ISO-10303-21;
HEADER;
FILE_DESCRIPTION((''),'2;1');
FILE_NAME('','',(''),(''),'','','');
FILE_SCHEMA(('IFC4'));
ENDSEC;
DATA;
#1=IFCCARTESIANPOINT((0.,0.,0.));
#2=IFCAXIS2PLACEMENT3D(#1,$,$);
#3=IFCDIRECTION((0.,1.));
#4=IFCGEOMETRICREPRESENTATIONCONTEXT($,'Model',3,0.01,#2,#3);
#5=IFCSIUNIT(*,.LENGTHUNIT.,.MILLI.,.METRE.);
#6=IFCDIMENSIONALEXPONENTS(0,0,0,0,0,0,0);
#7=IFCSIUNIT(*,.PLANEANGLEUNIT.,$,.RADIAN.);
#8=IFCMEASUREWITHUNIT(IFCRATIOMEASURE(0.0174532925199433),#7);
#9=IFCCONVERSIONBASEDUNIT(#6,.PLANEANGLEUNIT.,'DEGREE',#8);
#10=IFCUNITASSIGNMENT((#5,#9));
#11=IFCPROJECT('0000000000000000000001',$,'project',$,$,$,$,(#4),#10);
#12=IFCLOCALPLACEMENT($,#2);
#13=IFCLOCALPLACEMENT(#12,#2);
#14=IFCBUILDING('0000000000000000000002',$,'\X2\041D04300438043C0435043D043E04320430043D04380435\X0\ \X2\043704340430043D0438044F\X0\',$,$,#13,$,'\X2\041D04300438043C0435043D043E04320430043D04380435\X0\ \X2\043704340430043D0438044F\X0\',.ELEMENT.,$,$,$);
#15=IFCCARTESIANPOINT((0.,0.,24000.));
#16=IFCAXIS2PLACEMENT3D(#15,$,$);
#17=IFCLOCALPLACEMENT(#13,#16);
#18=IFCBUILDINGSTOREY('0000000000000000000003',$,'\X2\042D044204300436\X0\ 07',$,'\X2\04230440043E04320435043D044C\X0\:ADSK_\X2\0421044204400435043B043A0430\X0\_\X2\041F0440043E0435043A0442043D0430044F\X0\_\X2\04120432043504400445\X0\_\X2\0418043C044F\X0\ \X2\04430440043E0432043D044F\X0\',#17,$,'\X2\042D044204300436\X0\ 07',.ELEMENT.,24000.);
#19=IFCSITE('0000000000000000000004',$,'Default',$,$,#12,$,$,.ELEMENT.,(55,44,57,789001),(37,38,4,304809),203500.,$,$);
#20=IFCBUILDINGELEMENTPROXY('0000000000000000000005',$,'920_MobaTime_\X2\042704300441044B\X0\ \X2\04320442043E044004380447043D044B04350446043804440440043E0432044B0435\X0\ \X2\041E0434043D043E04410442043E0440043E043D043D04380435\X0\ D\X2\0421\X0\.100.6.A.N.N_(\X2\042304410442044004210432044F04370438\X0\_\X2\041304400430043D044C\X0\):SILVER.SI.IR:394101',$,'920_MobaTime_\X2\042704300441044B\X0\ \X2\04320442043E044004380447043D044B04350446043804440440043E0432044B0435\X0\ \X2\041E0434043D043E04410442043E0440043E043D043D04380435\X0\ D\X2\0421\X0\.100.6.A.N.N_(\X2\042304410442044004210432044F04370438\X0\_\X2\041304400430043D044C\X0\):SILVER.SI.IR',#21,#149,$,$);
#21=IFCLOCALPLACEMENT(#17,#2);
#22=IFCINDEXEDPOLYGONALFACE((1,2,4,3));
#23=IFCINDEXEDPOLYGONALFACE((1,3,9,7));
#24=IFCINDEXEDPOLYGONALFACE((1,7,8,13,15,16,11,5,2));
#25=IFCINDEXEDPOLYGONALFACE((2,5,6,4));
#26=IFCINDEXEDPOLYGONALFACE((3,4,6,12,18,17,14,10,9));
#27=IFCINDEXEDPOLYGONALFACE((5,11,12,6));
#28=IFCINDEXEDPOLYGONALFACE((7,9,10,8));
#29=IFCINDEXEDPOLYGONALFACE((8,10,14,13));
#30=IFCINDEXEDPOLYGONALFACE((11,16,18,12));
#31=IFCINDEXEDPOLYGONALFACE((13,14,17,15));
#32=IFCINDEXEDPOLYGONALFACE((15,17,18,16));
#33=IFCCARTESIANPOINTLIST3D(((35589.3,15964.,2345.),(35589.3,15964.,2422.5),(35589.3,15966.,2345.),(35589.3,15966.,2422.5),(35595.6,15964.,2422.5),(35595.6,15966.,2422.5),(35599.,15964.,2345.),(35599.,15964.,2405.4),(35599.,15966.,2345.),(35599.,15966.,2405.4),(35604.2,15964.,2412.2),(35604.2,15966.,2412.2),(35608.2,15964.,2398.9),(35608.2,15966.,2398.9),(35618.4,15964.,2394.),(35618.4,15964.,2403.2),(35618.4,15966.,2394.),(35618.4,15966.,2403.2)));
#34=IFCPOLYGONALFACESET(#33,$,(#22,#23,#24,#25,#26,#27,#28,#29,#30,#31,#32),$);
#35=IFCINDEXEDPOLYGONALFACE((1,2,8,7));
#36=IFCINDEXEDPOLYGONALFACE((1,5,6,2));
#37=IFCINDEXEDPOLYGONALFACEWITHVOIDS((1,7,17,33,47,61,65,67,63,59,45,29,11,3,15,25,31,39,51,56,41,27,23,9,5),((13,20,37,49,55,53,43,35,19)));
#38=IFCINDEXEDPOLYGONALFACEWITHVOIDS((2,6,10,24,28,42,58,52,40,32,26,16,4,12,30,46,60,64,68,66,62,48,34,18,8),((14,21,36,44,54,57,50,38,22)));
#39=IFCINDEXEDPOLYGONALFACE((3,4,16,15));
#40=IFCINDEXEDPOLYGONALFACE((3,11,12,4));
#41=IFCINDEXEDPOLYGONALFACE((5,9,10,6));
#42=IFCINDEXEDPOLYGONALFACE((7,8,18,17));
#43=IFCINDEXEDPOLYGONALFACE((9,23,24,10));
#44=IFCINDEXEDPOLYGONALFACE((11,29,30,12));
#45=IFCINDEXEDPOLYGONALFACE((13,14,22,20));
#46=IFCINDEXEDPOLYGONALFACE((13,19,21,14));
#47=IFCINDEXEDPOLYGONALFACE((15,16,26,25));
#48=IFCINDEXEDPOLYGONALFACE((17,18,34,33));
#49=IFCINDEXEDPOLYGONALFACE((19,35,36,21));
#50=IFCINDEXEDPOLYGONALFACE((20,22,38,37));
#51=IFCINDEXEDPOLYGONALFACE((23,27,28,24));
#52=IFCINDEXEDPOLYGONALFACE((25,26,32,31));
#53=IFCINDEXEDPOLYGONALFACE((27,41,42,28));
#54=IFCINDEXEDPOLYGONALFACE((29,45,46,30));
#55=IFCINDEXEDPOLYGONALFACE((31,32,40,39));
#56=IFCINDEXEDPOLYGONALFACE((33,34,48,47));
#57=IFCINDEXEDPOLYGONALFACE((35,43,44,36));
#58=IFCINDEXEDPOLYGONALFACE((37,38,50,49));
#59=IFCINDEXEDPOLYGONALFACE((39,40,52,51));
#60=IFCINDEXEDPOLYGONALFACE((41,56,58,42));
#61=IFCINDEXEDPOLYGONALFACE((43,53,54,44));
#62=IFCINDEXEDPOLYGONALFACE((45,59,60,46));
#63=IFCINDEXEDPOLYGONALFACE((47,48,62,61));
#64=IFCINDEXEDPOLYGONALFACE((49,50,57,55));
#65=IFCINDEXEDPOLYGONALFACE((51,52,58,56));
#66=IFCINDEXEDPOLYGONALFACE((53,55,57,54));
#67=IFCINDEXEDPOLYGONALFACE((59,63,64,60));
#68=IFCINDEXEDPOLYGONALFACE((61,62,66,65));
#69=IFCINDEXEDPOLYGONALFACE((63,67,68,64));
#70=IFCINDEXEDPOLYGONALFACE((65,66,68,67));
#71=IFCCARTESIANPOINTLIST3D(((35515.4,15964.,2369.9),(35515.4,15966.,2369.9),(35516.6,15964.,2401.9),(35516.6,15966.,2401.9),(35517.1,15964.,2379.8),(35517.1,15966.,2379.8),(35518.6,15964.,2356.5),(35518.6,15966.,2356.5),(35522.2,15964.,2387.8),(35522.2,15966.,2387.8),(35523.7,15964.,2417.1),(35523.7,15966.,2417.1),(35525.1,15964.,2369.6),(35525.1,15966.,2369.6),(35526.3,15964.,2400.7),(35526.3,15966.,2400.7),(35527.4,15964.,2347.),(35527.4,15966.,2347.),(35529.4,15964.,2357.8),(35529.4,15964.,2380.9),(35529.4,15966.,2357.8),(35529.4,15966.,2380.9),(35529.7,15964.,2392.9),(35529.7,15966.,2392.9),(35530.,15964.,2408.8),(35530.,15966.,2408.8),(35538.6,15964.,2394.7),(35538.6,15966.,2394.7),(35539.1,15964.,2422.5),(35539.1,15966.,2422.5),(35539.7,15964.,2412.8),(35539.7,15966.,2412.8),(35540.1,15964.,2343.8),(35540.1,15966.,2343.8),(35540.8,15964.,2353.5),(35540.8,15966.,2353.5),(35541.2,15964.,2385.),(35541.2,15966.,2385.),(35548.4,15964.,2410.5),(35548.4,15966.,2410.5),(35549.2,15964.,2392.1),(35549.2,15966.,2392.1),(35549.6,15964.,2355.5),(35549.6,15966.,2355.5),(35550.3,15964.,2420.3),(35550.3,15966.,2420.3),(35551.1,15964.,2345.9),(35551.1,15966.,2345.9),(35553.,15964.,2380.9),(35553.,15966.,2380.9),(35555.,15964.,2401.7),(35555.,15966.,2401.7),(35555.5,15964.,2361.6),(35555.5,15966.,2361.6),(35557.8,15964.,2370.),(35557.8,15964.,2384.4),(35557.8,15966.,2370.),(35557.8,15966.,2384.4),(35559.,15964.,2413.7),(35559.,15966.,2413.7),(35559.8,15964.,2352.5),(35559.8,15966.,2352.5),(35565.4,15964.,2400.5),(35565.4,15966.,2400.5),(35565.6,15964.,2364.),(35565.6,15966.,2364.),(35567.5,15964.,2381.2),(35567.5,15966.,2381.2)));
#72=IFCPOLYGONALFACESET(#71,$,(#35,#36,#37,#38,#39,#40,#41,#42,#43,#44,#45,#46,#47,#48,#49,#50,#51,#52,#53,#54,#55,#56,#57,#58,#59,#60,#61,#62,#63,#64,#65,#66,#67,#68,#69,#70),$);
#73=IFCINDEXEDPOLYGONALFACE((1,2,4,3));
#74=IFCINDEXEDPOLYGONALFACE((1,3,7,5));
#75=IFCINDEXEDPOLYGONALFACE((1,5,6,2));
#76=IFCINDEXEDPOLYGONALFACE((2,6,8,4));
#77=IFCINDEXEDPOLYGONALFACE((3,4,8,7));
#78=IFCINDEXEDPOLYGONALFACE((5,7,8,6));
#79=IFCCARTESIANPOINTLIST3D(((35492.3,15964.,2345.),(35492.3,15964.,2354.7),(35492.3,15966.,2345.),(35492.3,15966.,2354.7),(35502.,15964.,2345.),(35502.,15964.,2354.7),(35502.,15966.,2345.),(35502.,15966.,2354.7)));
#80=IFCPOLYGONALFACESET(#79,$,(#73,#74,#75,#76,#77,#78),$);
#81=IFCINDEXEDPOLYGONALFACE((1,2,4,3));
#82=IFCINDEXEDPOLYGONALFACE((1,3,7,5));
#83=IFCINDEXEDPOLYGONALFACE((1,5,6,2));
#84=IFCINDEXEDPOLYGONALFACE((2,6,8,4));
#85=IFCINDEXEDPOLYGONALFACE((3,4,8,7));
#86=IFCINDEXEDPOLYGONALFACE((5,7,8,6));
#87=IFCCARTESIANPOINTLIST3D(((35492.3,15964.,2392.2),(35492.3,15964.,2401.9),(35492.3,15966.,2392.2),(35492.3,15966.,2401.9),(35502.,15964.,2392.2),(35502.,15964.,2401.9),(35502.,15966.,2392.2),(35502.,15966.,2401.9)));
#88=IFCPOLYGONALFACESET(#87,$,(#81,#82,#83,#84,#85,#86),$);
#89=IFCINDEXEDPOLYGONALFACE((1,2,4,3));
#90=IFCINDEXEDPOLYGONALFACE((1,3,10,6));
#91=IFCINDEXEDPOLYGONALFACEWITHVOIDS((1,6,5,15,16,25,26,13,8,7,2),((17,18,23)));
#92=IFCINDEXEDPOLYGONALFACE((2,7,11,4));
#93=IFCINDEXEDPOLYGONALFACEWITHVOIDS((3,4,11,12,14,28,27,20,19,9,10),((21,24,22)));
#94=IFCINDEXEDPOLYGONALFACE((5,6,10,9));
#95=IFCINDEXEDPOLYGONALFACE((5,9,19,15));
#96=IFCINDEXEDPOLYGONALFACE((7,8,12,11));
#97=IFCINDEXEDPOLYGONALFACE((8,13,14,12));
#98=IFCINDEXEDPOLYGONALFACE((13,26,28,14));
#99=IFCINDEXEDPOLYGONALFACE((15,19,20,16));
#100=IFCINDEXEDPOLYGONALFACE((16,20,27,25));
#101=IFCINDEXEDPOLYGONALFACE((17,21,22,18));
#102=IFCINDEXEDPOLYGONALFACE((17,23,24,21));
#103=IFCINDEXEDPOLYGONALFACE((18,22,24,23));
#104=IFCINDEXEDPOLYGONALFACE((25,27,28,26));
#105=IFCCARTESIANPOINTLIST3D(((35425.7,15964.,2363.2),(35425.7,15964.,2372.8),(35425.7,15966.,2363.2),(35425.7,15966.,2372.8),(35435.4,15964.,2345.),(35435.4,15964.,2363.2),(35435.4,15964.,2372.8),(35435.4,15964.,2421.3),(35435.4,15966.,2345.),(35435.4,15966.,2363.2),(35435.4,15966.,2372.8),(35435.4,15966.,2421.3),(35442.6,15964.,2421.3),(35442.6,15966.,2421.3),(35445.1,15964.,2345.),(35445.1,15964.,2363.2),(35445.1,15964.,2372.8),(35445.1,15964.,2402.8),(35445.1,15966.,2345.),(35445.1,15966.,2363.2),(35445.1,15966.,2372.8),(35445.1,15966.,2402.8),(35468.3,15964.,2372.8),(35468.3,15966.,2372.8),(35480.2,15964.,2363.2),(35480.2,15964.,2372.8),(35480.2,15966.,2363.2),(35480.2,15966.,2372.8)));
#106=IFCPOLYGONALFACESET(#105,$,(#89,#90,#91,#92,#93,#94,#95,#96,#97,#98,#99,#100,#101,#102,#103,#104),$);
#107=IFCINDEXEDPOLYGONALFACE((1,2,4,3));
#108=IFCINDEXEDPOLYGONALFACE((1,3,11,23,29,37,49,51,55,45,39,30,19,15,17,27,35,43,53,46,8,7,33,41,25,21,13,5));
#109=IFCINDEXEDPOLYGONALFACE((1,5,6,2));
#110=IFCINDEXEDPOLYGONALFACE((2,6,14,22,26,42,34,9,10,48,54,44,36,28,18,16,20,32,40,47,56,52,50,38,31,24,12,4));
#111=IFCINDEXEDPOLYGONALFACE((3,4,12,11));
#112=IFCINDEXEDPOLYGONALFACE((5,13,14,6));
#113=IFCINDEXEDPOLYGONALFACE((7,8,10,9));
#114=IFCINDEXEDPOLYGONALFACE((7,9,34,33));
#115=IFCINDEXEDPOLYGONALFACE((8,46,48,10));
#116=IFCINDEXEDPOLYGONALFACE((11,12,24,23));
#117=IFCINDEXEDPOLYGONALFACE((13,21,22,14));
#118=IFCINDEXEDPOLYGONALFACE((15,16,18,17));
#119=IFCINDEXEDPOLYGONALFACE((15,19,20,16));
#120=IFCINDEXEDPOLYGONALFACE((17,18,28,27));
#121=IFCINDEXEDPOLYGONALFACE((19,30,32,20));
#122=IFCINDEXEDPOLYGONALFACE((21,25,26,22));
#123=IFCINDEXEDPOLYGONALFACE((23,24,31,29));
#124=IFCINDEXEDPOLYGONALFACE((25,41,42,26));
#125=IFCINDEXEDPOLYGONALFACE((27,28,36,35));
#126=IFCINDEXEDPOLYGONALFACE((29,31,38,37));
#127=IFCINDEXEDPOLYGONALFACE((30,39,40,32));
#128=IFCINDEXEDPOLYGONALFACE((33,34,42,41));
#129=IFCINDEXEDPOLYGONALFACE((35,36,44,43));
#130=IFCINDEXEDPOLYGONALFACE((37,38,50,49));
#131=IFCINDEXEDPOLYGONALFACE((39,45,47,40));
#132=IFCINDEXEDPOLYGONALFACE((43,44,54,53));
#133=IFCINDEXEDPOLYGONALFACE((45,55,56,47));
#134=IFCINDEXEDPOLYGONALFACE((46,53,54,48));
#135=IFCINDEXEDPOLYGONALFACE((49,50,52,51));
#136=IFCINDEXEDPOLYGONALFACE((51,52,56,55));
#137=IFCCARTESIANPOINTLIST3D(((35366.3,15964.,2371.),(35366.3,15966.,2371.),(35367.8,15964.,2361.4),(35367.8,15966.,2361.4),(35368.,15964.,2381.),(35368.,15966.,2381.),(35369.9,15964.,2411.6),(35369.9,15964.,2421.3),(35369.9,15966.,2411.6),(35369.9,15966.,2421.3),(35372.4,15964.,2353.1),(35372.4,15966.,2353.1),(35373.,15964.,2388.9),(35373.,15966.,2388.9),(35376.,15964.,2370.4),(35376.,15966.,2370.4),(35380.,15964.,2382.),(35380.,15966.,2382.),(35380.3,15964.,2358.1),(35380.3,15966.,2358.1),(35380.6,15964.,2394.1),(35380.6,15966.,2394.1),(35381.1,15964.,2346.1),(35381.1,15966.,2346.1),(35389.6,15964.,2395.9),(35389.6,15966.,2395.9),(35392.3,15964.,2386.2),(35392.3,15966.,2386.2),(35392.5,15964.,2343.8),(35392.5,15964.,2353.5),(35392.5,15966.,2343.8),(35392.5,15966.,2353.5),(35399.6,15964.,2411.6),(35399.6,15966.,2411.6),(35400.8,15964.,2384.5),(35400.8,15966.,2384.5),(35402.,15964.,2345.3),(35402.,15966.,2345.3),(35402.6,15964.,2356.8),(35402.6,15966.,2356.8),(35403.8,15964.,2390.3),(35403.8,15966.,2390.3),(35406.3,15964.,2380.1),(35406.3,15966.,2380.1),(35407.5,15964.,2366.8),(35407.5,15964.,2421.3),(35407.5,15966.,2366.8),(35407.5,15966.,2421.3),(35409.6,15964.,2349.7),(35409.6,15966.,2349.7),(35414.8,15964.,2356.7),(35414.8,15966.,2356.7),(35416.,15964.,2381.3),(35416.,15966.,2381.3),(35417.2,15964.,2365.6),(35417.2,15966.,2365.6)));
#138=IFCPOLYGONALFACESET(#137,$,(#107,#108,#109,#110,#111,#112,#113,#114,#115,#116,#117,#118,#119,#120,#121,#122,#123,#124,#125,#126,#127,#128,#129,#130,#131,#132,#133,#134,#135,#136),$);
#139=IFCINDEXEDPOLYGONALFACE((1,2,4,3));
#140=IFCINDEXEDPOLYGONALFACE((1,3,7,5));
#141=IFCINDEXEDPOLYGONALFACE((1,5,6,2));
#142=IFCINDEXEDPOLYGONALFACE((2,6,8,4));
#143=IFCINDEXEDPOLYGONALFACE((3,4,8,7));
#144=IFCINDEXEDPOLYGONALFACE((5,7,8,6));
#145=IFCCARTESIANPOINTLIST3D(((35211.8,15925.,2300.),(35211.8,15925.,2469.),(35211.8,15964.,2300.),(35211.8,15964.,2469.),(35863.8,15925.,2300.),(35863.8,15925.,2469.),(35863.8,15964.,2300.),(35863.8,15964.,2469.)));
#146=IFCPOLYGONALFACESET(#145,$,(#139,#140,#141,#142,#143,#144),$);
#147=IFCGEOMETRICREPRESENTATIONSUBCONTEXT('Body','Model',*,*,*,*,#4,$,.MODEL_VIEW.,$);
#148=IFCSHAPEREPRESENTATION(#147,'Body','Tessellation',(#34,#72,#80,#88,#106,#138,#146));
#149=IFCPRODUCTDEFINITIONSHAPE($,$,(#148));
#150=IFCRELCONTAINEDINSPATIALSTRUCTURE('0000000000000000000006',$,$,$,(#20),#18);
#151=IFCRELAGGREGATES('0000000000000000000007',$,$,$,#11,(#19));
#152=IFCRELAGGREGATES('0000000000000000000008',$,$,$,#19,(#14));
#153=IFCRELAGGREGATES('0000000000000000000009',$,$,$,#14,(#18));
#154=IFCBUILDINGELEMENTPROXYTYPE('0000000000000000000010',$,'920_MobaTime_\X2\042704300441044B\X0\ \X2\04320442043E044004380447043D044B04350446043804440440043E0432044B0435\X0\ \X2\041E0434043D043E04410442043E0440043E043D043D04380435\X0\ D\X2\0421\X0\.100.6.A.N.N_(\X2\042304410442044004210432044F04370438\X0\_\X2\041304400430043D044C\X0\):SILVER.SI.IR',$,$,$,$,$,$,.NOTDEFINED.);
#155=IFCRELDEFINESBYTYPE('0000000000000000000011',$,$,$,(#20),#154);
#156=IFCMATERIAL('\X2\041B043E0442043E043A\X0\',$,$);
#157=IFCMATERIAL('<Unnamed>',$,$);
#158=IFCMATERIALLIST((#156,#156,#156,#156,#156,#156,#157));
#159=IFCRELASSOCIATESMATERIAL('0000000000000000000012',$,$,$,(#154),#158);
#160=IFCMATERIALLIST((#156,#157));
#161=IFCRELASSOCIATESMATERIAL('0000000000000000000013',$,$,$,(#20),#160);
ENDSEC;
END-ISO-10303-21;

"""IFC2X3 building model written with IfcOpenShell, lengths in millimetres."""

from ifc_helpers import new_model, entity, si_unit, converted_unit, direction, frame, origin, origin_2d_with_axis, place, context, subcontext, project, spatial, polyline, rectangle, outline, extrude, source, transform, mapped, material, material_list, type_object, type_shapes, element, save


model = new_model("IFC2X3")

# Units and contexts
model_context = context("Model", 3, precision=0.01, world=origin(), true_north=direction((0.0, 1.0)))
body_context = subcontext(model_context, "Body", "Model", "MODEL_VIEW")
ifc_project = project(units=[si_unit("LENGTHUNIT", "METRE", prefix="MILLI"), converted_unit("PLANEANGLEUNIT", "DEGREE", entity("IfcRatioMeasure", 0.0174532925199433), si_unit("PLANEANGLEUNIT", "RADIAN"), dimensions=[0, 0, 0, 0, 0, 0, 0])], contexts=[model_context])

# Site, building, storey
site_placement = place(None, frame((0.0, 0.0, 0.0)))
site = spatial("IfcSite", under=ifc_project, at=site_placement, Name="Default", CompositionType="ELEMENT", RefLatitude=(55, 44, 57, 789001), RefLongitude=(37, 38, 4, 304809), RefElevation=203500.0)
building_placement = place(site_placement, origin())
building = spatial("IfcBuilding", under=site, at=building_placement, Name="Наименование здания", LongName="Наименование здания", CompositionType="ELEMENT")
storey_placement = place(building_placement, frame((0.0, 0.0, 24000.0)))
storey = spatial("IfcBuildingStorey", under=building, at=storey_placement, Name="Этаж 07", ObjectType="Уровень:ADSK_Стрелка_Проектная_Вверх_Имя уровня", LongName="Этаж 07", CompositionType="ELEMENT", Elevation=24000.0)

# Building element proxy
ifc_material_1 = material(Name="Лоток")
ifc_material_2 = material(Name="<Unnamed>")
ifc_material_list_1 = material_list([ifc_material_1, ifc_material_1, ifc_material_1, ifc_material_1, ifc_material_1, ifc_material_1, ifc_material_2])
building_element_proxy_type = type_object("IfcBuildingElementProxyType", Name="920_MobaTime_Часы вторичныецифровые Односторонние DС.100.6.A.N.N_(УстрСвязи_Грань):SILVER.SI.IR", PredefinedType="NOTDEFINED", material=ifc_material_list_1)
shared_shape = source(origin(), body_context, "Body", "SweptSolid", [
    extrude(outline(polyline([(-49.3, -13.1), (28.2, -13.1), (28.2, -6.8), (17.9, 1.8), (8.9, 16.0), (-0.3, 16.0), (4.6, 5.8), (11.1, -3.4), (-49.3, -3.4), (-49.3, -13.1)])), frame((-64.6, 9.8, 39.0), z_axis=(0.0, 0.0, 1.0), x_axis=(0.0, 1.0, 0.0)), (0.0, 0.0, 1.0), 2.0),
    extrude(outline(polyline([(2.2, -27.6), (19.0, -27.6), (30.5, -16.1), (33.3, -4.9), (31.0, 5.8), (21.8, 17.2), (5.2, 27.3), (-11.1, 33.0), (-24.0, 32.7), (-33.6, 27.6), (-40.3, 18.6), (-42.8, 5.7), (-38.0, -6.3), (-27.2, -15.0), (-17.5, -17.7), (-8.2, -16.4), (-0.3, -11.9), (5.1, -4.5), (7.3, 6.2), (4.0, 17.2), (18.5, 7.3), (23.6, -2.4), (22.0, -11.4), (14.2, -18.4), (5.3, -18.3), (2.2, -27.6)]), holes=[polyline([(-9.0, 23.3), (-1.3, 14.4), (-2.6, 2.0), (-11.4, -7.0), (-23.4, -6.1), (-32.2, 2.9), (-31.2, 15.1), (-25.6, 22.1), (-17.5, 24.9), (-9.0, 23.3)])]), frame((-2.7, 3.6, 39.0), z_axis=(0.0, 0.0, 1.0), x_axis=(-0.427649, 0.903945, 0.0)), (0.0, 0.0, 1.0), 2.0),
    extrude(rectangle(XDim=9.7, YDim=9.7, at=origin_2d_with_axis()), frame((40.6, -34.7, 39.0)), (0.0, 0.0, 1.0), 2.0),
    extrude(rectangle(XDim=9.7, YDim=9.7, at=origin_2d_with_axis()), frame((40.6, 12.6, 39.0)), (0.0, 0.0, 1.0), 2.0),
    extrude(outline(polyline([(-0.9, -28.1), (8.8, -28.1), (8.8, -9.9), (18.5, -9.9), (18.5, -0.2), (8.8, -0.2), (8.8, 48.3), (1.5, 48.3), (-36.0, -0.2), (-36.0, -9.9), (-0.9, -9.9), (-0.9, -28.1)]), holes=[polyline([(-0.9, -0.2), (-24.1, -0.2), (-0.9, 29.7), (-0.9, -0.2)])]), frame((93.6, -11.4, 39.0)), (0.0, 0.0, 1.0), 2.0),
    extrude(outline(polyline([(3.3, -28.3), (12.5, -28.3), (20.5, -25.0), (26.8, -18.8), (30.7, -10.0), (31.4, 1.6), (26.9, 11.8), (20.1, 18.4), (11.1, 22.3), (1.0, 23.3), (-7.9, 20.4), (-14.9, 14.5), (-18.9, 6.2), (-17.1, -9.0), (-36.7, 0.5), (-29.1, 29.3), (-38.5, 31.7), (-48.1, -4.6), (-11.6, -23.0), (-8.0, -14.0), (-10.8, -7.6), (-10.2, 1.1), (-3.0, 11.8), (9.2, 12.8), (20.0, 5.4), (21.3, -7.5), (15.5, -16.4), (4.6, -18.6), (3.3, -28.3)])), frame((147.1, -8.5, 39.0), z_axis=(0.0, 0.0, 1.0), x_axis=(0.256974, -0.966418, 0.0)), (0.0, 0.0, 1.0), 2.0),
    extrude(rectangle(XDim=652.0, YDim=169.0, at=origin_2d_with_axis()), frame((0.0, 0.0, 0.0), z_axis=(0.0, 0.0, 1.0), x_axis=(-1.0, 0.0, 0.0)), (0.0, 0.0, 1.0), 39.0),
])
type_shapes(building_element_proxy_type, [shared_shape])
ifc_material_list_2 = material_list([ifc_material_1, ifc_material_2])
proxy_1_placement = place(storey_placement, frame((35537.8, 15925.0, 2384.5), z_axis=(0.0, 1.0, 0.0), x_axis=(-1.0, 0.0, 0.0)))
element("IfcBuildingElementProxy", 1, at=proxy_1_placement, inside=storey, type_object=building_element_proxy_type, material=ifc_material_list_2, Name="920_MobaTime_Часы вторичныецифровые Односторонние DС.100.6.A.N.N_(УстрСвязи_Грань):SILVER.SI.IR:394101", ObjectType="920_MobaTime_Часы вторичныецифровые Односторонние DС.100.6.A.N.N_(УстрСвязи_Грань):SILVER.SI.IR", context=body_context, shape_type="MappedRepresentation", body=[
    mapped(shared_shape, transform((0.0, 0.0, 0.0), scale=1.0)),
])

save(model, "model.ifc")
